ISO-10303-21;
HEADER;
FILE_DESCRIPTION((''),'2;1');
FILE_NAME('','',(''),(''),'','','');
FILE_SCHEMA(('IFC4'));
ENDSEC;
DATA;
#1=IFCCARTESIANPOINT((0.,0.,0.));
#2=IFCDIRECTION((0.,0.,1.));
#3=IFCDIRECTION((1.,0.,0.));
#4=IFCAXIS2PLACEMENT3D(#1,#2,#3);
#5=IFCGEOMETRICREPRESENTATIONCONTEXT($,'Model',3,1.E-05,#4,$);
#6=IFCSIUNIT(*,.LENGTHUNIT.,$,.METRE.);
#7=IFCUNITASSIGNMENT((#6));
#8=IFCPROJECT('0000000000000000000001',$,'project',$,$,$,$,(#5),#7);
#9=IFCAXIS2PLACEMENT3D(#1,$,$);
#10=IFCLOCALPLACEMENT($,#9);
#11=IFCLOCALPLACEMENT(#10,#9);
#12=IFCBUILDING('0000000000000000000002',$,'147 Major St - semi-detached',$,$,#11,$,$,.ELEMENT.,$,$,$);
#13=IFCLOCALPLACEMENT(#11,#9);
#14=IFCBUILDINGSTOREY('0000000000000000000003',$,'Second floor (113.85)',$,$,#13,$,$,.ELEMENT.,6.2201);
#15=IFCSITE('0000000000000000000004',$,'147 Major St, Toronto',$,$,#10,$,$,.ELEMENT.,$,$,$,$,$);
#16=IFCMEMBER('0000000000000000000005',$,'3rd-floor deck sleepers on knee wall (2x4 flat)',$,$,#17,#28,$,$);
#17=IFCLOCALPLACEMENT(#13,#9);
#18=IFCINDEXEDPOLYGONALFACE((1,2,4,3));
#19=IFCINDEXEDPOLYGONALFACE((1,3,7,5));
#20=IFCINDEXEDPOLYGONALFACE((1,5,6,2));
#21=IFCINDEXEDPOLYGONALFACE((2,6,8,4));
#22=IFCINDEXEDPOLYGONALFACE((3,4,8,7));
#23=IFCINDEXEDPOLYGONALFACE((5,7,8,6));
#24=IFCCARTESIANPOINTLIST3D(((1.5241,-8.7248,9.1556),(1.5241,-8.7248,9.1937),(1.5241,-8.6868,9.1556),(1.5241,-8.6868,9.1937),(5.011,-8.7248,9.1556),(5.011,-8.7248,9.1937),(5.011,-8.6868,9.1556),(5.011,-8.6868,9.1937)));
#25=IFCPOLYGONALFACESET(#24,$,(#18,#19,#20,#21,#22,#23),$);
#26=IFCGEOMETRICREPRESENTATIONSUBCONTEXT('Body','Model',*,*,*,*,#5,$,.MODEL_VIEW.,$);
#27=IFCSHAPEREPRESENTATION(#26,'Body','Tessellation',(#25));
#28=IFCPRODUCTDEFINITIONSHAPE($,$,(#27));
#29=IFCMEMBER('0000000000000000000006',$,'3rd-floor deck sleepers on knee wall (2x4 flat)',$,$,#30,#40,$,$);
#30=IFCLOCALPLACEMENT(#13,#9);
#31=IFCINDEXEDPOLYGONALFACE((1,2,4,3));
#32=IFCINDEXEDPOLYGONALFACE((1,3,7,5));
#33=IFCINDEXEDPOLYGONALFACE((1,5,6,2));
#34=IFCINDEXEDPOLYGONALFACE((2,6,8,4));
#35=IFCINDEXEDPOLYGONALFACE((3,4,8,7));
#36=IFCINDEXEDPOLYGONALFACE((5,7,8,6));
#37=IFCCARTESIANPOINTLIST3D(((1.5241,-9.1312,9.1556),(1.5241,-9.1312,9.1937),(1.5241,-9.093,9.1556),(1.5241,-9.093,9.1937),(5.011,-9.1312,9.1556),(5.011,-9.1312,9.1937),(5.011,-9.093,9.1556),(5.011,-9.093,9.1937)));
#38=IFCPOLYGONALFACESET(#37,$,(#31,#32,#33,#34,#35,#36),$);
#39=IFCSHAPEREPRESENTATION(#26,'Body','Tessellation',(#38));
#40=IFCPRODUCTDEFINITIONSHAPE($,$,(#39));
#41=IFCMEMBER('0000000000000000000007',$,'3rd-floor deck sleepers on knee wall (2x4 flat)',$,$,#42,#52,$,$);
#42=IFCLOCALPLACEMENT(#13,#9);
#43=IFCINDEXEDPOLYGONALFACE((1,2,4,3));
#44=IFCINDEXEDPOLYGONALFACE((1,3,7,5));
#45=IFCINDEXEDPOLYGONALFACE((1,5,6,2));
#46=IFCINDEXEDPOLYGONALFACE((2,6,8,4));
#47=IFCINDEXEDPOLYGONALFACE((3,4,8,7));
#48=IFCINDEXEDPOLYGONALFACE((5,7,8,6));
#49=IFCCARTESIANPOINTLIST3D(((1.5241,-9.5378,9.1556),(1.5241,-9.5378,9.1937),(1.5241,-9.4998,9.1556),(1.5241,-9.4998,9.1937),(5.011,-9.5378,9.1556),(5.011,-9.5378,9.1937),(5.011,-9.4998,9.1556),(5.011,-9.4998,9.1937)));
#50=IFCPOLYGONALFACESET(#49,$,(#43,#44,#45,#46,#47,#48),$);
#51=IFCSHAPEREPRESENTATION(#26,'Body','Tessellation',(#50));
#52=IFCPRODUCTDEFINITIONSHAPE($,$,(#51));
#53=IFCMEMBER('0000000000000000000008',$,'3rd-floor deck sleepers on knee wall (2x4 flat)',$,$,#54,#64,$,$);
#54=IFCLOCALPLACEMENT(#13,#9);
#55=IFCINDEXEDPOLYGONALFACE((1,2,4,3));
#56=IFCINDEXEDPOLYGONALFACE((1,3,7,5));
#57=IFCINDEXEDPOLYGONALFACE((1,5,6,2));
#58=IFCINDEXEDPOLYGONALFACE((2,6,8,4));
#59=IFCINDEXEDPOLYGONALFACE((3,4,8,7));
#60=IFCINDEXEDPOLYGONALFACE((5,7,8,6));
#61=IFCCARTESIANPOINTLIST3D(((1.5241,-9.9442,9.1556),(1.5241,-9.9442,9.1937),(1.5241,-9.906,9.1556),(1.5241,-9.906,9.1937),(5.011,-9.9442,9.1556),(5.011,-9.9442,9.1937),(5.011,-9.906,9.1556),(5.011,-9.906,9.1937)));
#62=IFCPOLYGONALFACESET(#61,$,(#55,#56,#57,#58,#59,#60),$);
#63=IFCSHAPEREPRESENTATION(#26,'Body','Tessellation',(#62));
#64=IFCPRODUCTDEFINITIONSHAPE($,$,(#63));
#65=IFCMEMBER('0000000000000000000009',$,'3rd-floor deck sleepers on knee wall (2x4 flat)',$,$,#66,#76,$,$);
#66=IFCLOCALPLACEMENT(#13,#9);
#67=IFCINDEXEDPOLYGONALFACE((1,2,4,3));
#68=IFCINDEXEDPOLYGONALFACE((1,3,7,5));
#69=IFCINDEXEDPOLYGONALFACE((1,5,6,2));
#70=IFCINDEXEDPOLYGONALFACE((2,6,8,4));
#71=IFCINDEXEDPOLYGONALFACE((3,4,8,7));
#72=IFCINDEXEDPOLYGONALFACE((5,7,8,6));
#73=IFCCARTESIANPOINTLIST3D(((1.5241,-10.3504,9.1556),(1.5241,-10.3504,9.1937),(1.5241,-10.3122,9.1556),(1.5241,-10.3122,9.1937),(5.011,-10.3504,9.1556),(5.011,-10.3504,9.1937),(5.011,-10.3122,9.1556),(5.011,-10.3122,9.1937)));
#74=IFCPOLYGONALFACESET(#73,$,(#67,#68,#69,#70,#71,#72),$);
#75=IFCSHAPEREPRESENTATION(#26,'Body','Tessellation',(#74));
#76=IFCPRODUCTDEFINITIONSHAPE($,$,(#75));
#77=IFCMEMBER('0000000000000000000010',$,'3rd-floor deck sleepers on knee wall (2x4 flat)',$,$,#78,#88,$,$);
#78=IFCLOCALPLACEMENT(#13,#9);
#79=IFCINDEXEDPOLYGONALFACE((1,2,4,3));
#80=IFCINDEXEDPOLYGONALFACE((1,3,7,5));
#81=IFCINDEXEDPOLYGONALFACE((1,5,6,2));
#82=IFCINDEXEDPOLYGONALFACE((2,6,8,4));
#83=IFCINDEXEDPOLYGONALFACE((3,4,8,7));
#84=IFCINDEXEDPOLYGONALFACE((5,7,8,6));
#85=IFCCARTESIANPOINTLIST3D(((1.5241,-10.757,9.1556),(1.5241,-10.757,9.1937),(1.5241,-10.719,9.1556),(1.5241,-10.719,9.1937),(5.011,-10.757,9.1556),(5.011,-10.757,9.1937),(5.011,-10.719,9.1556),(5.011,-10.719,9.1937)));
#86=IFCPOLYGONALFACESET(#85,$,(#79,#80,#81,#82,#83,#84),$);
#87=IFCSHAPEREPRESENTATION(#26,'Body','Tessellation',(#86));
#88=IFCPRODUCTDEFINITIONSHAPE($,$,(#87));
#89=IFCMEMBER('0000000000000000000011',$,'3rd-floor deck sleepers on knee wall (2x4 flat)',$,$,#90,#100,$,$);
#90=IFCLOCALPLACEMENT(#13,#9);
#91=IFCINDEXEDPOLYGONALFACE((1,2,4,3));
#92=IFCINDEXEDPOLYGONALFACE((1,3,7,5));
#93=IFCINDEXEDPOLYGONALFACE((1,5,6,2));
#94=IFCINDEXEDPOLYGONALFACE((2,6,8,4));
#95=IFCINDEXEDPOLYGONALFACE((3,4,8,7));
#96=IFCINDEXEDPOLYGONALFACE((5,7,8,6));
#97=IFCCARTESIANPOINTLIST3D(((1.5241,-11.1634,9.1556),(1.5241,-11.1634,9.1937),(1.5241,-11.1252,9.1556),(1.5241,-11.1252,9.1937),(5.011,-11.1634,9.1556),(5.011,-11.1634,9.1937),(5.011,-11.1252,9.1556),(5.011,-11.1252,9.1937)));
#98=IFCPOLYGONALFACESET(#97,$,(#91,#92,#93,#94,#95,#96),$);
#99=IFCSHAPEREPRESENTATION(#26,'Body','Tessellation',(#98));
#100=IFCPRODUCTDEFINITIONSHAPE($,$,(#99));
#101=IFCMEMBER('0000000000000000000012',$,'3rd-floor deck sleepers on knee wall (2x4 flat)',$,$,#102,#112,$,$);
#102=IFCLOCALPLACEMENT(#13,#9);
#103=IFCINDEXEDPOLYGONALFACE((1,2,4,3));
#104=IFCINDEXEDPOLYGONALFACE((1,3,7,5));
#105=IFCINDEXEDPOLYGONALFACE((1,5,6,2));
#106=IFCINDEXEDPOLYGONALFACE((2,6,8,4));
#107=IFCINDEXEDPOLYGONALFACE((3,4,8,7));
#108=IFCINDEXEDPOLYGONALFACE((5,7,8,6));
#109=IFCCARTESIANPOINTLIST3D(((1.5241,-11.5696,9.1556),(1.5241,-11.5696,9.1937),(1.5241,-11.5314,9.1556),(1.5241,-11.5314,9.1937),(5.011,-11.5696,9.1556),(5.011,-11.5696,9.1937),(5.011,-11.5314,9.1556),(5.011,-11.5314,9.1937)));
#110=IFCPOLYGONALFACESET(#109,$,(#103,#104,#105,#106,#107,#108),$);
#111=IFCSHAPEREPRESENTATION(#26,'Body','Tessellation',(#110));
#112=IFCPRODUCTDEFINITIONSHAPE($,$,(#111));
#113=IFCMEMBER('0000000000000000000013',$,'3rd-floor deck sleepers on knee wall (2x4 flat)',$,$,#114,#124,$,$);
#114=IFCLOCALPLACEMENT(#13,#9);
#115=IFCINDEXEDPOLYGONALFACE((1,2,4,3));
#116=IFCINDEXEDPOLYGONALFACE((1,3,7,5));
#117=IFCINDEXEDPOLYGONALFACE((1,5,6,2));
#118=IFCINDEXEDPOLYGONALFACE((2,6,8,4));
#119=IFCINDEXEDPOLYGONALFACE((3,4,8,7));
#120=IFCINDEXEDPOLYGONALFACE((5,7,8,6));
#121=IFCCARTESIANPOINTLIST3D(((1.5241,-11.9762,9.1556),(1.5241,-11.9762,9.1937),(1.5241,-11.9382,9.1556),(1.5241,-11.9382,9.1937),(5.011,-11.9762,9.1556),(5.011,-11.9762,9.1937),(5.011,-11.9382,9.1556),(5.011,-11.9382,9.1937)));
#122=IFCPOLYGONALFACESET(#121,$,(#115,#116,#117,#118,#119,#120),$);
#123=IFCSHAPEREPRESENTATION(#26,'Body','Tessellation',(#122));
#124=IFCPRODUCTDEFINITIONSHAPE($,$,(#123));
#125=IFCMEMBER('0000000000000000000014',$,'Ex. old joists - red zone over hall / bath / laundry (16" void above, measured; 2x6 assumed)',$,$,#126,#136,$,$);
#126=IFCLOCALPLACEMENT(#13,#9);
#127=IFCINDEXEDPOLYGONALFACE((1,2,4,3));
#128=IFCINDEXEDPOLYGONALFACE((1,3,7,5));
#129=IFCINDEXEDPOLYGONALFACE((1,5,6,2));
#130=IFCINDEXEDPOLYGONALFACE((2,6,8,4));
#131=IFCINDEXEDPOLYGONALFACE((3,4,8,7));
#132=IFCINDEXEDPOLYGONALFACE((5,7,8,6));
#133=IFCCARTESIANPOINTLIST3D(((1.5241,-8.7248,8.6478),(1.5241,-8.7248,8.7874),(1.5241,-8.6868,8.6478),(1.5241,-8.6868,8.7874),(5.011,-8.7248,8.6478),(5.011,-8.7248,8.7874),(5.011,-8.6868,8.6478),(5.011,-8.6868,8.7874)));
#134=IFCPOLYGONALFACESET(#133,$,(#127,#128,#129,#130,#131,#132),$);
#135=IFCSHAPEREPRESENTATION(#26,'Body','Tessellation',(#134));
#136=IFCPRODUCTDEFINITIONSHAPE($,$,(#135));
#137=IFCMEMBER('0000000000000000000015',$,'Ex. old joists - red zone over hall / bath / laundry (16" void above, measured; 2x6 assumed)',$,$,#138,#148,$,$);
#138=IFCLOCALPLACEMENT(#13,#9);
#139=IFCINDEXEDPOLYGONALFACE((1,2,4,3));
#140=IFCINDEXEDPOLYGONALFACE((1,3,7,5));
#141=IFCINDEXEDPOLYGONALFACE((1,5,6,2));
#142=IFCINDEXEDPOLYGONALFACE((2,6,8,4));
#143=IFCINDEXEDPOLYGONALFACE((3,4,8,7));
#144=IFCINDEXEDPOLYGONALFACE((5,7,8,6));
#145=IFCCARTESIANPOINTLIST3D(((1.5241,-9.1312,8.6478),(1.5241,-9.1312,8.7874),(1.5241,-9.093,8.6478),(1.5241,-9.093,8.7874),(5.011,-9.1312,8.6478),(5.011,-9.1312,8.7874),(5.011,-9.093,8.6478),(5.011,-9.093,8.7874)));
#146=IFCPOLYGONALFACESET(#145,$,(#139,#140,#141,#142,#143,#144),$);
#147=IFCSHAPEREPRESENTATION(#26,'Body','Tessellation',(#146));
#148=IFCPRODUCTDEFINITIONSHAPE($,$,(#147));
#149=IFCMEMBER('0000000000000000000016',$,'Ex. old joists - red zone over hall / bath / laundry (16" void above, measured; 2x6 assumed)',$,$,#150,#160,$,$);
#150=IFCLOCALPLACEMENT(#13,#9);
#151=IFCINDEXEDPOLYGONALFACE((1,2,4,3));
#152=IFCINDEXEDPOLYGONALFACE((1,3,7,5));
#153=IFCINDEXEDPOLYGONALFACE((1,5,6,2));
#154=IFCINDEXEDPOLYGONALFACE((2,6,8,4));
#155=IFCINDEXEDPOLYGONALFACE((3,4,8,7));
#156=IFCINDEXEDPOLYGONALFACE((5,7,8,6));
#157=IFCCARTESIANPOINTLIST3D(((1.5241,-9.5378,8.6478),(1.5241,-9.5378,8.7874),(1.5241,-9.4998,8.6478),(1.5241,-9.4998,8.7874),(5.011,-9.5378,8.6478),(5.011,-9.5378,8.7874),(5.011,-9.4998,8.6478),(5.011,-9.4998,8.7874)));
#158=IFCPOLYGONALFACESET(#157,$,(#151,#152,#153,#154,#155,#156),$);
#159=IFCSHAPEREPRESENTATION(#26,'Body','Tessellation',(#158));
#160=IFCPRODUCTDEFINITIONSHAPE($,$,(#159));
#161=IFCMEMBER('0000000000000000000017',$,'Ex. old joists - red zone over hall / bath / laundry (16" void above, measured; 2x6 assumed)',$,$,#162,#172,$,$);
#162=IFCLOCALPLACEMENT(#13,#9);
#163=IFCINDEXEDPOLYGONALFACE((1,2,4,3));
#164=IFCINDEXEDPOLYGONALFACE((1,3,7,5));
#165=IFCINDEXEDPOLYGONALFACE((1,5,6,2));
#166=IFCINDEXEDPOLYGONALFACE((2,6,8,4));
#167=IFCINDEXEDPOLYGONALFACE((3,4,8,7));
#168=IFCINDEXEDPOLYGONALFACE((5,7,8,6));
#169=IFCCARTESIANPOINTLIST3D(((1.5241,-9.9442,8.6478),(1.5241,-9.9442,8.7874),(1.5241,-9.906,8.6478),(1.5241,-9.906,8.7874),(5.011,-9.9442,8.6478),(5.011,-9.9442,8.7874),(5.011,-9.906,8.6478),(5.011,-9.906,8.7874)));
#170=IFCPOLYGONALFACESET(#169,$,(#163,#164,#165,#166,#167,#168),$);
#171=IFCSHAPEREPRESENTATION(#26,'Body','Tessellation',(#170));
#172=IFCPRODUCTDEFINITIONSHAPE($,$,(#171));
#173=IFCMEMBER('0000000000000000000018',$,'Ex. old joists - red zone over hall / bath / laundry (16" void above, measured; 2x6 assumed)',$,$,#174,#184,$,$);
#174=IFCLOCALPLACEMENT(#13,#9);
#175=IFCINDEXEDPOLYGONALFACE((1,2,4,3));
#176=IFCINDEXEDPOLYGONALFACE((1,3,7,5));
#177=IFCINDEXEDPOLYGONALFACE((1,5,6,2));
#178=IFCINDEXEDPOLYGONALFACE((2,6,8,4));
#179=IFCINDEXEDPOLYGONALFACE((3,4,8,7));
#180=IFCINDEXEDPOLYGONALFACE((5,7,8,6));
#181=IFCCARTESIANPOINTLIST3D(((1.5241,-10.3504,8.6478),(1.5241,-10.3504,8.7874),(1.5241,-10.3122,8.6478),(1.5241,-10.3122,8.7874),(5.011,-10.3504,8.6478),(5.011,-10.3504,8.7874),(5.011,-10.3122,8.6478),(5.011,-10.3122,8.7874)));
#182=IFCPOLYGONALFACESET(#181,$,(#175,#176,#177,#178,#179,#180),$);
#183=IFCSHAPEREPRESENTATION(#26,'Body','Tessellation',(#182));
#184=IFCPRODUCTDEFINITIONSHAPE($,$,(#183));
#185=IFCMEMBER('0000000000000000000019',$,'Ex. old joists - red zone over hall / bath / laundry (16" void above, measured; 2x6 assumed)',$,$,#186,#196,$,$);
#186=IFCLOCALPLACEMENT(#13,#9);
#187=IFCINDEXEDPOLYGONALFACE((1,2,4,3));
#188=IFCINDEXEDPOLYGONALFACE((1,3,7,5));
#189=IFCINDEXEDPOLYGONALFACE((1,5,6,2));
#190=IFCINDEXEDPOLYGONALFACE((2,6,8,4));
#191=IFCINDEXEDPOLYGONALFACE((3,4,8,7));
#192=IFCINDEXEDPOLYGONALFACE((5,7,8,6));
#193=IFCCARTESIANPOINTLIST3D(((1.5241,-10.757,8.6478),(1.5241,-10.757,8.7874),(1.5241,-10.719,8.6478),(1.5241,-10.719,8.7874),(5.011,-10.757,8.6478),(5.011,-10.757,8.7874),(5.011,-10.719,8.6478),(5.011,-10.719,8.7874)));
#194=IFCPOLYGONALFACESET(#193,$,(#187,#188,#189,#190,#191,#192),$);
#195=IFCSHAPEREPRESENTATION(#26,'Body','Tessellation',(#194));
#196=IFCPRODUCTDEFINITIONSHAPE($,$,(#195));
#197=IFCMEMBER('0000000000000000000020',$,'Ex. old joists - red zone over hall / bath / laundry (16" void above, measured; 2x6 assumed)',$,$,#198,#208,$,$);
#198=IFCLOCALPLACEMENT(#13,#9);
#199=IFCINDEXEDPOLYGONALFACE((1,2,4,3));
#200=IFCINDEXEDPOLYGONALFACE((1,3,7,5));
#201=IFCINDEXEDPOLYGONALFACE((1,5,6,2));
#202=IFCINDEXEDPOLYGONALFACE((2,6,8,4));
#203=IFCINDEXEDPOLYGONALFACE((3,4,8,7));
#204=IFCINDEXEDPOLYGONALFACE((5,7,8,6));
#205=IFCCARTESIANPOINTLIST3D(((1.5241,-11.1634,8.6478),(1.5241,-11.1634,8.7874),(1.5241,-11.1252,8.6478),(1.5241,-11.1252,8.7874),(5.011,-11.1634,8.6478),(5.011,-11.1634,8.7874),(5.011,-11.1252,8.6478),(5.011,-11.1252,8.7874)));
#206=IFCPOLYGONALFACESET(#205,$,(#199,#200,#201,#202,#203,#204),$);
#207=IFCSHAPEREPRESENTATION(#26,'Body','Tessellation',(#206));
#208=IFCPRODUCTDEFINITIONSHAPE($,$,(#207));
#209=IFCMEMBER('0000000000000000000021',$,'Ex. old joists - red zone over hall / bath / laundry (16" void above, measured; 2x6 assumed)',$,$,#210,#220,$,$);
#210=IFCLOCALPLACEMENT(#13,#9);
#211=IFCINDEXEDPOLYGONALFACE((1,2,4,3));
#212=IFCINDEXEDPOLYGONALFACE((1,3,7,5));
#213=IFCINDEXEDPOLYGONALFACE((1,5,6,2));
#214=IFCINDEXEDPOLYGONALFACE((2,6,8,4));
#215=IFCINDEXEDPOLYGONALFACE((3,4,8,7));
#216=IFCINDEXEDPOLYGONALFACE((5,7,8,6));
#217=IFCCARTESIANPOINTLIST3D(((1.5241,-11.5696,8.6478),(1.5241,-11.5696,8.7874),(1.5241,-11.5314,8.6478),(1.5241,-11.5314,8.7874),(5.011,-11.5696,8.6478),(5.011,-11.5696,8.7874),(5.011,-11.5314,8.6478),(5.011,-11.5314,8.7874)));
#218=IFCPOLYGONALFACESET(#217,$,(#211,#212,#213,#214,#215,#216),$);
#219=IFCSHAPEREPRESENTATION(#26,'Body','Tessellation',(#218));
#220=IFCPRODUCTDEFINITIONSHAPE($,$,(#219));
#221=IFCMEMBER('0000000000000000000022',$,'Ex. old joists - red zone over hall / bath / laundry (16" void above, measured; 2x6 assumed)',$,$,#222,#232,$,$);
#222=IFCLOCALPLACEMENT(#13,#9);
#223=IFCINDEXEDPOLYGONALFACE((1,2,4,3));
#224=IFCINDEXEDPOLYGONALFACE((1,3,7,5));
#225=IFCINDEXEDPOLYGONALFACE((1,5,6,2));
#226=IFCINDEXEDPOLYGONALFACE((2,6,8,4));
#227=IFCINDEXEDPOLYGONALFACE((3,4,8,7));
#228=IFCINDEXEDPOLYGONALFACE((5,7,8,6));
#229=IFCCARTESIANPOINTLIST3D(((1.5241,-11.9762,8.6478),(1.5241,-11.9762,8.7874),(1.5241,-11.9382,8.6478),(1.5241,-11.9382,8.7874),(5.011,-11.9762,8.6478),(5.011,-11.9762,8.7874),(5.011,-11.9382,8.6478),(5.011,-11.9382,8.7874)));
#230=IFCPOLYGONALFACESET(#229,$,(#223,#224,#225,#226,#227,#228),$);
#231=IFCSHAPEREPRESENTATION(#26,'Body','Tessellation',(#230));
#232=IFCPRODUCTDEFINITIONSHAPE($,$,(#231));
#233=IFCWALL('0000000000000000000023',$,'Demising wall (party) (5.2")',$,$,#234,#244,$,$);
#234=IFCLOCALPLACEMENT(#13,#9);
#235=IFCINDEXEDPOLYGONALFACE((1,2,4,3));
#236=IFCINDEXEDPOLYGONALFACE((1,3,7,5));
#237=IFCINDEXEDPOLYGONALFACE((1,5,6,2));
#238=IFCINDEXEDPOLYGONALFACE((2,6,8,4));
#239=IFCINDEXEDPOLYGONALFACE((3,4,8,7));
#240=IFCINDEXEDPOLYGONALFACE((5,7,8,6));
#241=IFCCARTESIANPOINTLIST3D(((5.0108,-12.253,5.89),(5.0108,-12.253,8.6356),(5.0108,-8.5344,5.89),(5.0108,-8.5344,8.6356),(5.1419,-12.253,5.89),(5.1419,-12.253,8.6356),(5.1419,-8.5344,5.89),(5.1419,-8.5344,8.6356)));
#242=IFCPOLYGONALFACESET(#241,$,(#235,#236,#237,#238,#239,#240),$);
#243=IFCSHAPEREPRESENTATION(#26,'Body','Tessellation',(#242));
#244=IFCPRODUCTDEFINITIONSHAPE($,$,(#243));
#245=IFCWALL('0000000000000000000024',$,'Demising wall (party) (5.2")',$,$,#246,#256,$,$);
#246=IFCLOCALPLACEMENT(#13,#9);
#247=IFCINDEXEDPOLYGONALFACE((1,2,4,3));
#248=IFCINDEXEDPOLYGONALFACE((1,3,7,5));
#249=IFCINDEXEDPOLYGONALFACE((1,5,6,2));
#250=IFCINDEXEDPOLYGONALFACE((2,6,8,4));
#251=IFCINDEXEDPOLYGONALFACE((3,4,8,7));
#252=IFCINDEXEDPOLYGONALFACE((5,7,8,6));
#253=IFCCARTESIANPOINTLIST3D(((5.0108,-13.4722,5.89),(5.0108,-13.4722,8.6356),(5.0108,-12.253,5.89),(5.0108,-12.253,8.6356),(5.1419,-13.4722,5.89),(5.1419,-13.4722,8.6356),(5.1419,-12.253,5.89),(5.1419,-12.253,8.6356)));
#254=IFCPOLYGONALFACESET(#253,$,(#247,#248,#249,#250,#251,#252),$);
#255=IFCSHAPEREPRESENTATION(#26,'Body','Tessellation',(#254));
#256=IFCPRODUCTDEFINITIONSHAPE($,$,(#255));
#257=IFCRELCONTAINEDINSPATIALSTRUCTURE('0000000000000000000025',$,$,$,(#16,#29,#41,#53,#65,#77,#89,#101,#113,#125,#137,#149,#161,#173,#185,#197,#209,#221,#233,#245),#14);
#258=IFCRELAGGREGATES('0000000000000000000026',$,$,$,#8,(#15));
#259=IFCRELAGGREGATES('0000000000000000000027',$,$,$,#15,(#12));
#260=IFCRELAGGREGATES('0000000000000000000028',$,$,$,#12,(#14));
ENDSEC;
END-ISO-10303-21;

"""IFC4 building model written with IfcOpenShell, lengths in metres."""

from ifc_helpers import new_model, si_unit, frame, origin, origin_with_axes, place, context, subcontext, project, spatial, rectangle, extrude, element, save


model = new_model("IFC4")

# Units and contexts
model_context = context("Model", 3, precision=1e-05, world=origin_with_axes())
body_context = subcontext(model_context, "Body", "Model", "MODEL_VIEW")
ifc_project = project(units=[si_unit("LENGTHUNIT", "METRE")], contexts=[model_context])

# Site, building, storey
site_placement = place(None, origin())
site = spatial("IfcSite", under=ifc_project, at=site_placement, Name="147 Major St, Toronto", CompositionType="ELEMENT")
building_placement = place(site_placement, origin())
building = spatial("IfcBuilding", under=site, at=building_placement, Name="147 Major St - semi-detached", CompositionType="ELEMENT")
storey_placement = place(building_placement, origin())
storey = spatial("IfcBuildingStorey", under=building, at=storey_placement, Name="Second floor (113.85)", CompositionType="ELEMENT", Elevation=6.2201)

# Members
for number, where, name in (
    (1, (3.2675, -8.7058, 9.1556), "3rd-floor deck sleepers on knee wall (2x4 flat)"),
    (2, (3.2675, -9.1121, 9.1556), "3rd-floor deck sleepers on knee wall (2x4 flat)"),
    (3, (3.2675, -9.5188, 9.1556), "3rd-floor deck sleepers on knee wall (2x4 flat)"),
    (4, (3.2675, -9.9251, 9.1556), "3rd-floor deck sleepers on knee wall (2x4 flat)"),
    (5, (3.2675, -10.3313, 9.1556), "3rd-floor deck sleepers on knee wall (2x4 flat)"),
    (6, (3.2675, -10.738, 9.1556), "3rd-floor deck sleepers on knee wall (2x4 flat)"),
    (7, (3.2675, -11.1443, 9.1556), "3rd-floor deck sleepers on knee wall (2x4 flat)"),
    (8, (3.2675, -11.5505, 9.1556), "3rd-floor deck sleepers on knee wall (2x4 flat)"),
    (9, (3.2675, -11.9572, 9.1556), "3rd-floor deck sleepers on knee wall (2x4 flat)"),
):
    element("IfcMember", number, at=place(storey_placement, frame(where)), inside=storey, Name=name, context=body_context, shape_type="SweptSolid", body=[
        extrude(rectangle(XDim=3.4869, YDim=0.0381), origin_with_axes(), (0.0, 0.0, 1.0), 0.0381),
    ])
for number, where, name in (
    (10, (3.2675, -8.7058, 8.6478), "Ex. old joists - red zone over hall / bath / laundry (16\" void above, measured; 2x6 assumed)"),
    (11, (3.2675, -9.1121, 8.6478), "Ex. old joists - red zone over hall / bath / laundry (16\" void above, measured; 2x6 assumed)"),
    (12, (3.2675, -9.5188, 8.6478), "Ex. old joists - red zone over hall / bath / laundry (16\" void above, measured; 2x6 assumed)"),
    (13, (3.2675, -9.9251, 8.6478), "Ex. old joists - red zone over hall / bath / laundry (16\" void above, measured; 2x6 assumed)"),
    (14, (3.2675, -10.3313, 8.6478), "Ex. old joists - red zone over hall / bath / laundry (16\" void above, measured; 2x6 assumed)"),
    (15, (3.2675, -10.738, 8.6478), "Ex. old joists - red zone over hall / bath / laundry (16\" void above, measured; 2x6 assumed)"),
    (16, (3.2675, -11.1443, 8.6478), "Ex. old joists - red zone over hall / bath / laundry (16\" void above, measured; 2x6 assumed)"),
    (17, (3.2675, -11.5505, 8.6478), "Ex. old joists - red zone over hall / bath / laundry (16\" void above, measured; 2x6 assumed)"),
    (18, (3.2675, -11.9572, 8.6478), "Ex. old joists - red zone over hall / bath / laundry (16\" void above, measured; 2x6 assumed)"),
):
    element("IfcMember", number, at=place(storey_placement, frame(where)), inside=storey, Name=name, context=body_context, shape_type="SweptSolid", body=[
        extrude(rectangle(XDim=3.4869, YDim=0.0381), origin_with_axes(), (0.0, 0.0, 1.0), 0.1396),
    ])

# Walls
wall_1_placement = place(storey_placement, frame((5.0764, -10.3937, 5.89)))
element("IfcWall", 19, at=wall_1_placement, inside=storey, Name="Demising wall (party) (5.2\")", context=body_context, shape_type="SweptSolid", body=[
    extrude(rectangle(XDim=0.1311, YDim=3.7186), origin_with_axes(), (0.0, 0.0, 1.0), 2.7456),
])
wall_2_placement = place(storey_placement, frame((5.0764, -12.8626, 5.89)))
element("IfcWall", 20, at=wall_2_placement, inside=storey, Name="Demising wall (party) (5.2\")", context=body_context, shape_type="SweptSolid", body=[
    extrude(rectangle(XDim=0.1311, YDim=1.2192), origin_with_axes(), (0.0, 0.0, 1.0), 2.7456),
])

save(model, "model.ifc")
